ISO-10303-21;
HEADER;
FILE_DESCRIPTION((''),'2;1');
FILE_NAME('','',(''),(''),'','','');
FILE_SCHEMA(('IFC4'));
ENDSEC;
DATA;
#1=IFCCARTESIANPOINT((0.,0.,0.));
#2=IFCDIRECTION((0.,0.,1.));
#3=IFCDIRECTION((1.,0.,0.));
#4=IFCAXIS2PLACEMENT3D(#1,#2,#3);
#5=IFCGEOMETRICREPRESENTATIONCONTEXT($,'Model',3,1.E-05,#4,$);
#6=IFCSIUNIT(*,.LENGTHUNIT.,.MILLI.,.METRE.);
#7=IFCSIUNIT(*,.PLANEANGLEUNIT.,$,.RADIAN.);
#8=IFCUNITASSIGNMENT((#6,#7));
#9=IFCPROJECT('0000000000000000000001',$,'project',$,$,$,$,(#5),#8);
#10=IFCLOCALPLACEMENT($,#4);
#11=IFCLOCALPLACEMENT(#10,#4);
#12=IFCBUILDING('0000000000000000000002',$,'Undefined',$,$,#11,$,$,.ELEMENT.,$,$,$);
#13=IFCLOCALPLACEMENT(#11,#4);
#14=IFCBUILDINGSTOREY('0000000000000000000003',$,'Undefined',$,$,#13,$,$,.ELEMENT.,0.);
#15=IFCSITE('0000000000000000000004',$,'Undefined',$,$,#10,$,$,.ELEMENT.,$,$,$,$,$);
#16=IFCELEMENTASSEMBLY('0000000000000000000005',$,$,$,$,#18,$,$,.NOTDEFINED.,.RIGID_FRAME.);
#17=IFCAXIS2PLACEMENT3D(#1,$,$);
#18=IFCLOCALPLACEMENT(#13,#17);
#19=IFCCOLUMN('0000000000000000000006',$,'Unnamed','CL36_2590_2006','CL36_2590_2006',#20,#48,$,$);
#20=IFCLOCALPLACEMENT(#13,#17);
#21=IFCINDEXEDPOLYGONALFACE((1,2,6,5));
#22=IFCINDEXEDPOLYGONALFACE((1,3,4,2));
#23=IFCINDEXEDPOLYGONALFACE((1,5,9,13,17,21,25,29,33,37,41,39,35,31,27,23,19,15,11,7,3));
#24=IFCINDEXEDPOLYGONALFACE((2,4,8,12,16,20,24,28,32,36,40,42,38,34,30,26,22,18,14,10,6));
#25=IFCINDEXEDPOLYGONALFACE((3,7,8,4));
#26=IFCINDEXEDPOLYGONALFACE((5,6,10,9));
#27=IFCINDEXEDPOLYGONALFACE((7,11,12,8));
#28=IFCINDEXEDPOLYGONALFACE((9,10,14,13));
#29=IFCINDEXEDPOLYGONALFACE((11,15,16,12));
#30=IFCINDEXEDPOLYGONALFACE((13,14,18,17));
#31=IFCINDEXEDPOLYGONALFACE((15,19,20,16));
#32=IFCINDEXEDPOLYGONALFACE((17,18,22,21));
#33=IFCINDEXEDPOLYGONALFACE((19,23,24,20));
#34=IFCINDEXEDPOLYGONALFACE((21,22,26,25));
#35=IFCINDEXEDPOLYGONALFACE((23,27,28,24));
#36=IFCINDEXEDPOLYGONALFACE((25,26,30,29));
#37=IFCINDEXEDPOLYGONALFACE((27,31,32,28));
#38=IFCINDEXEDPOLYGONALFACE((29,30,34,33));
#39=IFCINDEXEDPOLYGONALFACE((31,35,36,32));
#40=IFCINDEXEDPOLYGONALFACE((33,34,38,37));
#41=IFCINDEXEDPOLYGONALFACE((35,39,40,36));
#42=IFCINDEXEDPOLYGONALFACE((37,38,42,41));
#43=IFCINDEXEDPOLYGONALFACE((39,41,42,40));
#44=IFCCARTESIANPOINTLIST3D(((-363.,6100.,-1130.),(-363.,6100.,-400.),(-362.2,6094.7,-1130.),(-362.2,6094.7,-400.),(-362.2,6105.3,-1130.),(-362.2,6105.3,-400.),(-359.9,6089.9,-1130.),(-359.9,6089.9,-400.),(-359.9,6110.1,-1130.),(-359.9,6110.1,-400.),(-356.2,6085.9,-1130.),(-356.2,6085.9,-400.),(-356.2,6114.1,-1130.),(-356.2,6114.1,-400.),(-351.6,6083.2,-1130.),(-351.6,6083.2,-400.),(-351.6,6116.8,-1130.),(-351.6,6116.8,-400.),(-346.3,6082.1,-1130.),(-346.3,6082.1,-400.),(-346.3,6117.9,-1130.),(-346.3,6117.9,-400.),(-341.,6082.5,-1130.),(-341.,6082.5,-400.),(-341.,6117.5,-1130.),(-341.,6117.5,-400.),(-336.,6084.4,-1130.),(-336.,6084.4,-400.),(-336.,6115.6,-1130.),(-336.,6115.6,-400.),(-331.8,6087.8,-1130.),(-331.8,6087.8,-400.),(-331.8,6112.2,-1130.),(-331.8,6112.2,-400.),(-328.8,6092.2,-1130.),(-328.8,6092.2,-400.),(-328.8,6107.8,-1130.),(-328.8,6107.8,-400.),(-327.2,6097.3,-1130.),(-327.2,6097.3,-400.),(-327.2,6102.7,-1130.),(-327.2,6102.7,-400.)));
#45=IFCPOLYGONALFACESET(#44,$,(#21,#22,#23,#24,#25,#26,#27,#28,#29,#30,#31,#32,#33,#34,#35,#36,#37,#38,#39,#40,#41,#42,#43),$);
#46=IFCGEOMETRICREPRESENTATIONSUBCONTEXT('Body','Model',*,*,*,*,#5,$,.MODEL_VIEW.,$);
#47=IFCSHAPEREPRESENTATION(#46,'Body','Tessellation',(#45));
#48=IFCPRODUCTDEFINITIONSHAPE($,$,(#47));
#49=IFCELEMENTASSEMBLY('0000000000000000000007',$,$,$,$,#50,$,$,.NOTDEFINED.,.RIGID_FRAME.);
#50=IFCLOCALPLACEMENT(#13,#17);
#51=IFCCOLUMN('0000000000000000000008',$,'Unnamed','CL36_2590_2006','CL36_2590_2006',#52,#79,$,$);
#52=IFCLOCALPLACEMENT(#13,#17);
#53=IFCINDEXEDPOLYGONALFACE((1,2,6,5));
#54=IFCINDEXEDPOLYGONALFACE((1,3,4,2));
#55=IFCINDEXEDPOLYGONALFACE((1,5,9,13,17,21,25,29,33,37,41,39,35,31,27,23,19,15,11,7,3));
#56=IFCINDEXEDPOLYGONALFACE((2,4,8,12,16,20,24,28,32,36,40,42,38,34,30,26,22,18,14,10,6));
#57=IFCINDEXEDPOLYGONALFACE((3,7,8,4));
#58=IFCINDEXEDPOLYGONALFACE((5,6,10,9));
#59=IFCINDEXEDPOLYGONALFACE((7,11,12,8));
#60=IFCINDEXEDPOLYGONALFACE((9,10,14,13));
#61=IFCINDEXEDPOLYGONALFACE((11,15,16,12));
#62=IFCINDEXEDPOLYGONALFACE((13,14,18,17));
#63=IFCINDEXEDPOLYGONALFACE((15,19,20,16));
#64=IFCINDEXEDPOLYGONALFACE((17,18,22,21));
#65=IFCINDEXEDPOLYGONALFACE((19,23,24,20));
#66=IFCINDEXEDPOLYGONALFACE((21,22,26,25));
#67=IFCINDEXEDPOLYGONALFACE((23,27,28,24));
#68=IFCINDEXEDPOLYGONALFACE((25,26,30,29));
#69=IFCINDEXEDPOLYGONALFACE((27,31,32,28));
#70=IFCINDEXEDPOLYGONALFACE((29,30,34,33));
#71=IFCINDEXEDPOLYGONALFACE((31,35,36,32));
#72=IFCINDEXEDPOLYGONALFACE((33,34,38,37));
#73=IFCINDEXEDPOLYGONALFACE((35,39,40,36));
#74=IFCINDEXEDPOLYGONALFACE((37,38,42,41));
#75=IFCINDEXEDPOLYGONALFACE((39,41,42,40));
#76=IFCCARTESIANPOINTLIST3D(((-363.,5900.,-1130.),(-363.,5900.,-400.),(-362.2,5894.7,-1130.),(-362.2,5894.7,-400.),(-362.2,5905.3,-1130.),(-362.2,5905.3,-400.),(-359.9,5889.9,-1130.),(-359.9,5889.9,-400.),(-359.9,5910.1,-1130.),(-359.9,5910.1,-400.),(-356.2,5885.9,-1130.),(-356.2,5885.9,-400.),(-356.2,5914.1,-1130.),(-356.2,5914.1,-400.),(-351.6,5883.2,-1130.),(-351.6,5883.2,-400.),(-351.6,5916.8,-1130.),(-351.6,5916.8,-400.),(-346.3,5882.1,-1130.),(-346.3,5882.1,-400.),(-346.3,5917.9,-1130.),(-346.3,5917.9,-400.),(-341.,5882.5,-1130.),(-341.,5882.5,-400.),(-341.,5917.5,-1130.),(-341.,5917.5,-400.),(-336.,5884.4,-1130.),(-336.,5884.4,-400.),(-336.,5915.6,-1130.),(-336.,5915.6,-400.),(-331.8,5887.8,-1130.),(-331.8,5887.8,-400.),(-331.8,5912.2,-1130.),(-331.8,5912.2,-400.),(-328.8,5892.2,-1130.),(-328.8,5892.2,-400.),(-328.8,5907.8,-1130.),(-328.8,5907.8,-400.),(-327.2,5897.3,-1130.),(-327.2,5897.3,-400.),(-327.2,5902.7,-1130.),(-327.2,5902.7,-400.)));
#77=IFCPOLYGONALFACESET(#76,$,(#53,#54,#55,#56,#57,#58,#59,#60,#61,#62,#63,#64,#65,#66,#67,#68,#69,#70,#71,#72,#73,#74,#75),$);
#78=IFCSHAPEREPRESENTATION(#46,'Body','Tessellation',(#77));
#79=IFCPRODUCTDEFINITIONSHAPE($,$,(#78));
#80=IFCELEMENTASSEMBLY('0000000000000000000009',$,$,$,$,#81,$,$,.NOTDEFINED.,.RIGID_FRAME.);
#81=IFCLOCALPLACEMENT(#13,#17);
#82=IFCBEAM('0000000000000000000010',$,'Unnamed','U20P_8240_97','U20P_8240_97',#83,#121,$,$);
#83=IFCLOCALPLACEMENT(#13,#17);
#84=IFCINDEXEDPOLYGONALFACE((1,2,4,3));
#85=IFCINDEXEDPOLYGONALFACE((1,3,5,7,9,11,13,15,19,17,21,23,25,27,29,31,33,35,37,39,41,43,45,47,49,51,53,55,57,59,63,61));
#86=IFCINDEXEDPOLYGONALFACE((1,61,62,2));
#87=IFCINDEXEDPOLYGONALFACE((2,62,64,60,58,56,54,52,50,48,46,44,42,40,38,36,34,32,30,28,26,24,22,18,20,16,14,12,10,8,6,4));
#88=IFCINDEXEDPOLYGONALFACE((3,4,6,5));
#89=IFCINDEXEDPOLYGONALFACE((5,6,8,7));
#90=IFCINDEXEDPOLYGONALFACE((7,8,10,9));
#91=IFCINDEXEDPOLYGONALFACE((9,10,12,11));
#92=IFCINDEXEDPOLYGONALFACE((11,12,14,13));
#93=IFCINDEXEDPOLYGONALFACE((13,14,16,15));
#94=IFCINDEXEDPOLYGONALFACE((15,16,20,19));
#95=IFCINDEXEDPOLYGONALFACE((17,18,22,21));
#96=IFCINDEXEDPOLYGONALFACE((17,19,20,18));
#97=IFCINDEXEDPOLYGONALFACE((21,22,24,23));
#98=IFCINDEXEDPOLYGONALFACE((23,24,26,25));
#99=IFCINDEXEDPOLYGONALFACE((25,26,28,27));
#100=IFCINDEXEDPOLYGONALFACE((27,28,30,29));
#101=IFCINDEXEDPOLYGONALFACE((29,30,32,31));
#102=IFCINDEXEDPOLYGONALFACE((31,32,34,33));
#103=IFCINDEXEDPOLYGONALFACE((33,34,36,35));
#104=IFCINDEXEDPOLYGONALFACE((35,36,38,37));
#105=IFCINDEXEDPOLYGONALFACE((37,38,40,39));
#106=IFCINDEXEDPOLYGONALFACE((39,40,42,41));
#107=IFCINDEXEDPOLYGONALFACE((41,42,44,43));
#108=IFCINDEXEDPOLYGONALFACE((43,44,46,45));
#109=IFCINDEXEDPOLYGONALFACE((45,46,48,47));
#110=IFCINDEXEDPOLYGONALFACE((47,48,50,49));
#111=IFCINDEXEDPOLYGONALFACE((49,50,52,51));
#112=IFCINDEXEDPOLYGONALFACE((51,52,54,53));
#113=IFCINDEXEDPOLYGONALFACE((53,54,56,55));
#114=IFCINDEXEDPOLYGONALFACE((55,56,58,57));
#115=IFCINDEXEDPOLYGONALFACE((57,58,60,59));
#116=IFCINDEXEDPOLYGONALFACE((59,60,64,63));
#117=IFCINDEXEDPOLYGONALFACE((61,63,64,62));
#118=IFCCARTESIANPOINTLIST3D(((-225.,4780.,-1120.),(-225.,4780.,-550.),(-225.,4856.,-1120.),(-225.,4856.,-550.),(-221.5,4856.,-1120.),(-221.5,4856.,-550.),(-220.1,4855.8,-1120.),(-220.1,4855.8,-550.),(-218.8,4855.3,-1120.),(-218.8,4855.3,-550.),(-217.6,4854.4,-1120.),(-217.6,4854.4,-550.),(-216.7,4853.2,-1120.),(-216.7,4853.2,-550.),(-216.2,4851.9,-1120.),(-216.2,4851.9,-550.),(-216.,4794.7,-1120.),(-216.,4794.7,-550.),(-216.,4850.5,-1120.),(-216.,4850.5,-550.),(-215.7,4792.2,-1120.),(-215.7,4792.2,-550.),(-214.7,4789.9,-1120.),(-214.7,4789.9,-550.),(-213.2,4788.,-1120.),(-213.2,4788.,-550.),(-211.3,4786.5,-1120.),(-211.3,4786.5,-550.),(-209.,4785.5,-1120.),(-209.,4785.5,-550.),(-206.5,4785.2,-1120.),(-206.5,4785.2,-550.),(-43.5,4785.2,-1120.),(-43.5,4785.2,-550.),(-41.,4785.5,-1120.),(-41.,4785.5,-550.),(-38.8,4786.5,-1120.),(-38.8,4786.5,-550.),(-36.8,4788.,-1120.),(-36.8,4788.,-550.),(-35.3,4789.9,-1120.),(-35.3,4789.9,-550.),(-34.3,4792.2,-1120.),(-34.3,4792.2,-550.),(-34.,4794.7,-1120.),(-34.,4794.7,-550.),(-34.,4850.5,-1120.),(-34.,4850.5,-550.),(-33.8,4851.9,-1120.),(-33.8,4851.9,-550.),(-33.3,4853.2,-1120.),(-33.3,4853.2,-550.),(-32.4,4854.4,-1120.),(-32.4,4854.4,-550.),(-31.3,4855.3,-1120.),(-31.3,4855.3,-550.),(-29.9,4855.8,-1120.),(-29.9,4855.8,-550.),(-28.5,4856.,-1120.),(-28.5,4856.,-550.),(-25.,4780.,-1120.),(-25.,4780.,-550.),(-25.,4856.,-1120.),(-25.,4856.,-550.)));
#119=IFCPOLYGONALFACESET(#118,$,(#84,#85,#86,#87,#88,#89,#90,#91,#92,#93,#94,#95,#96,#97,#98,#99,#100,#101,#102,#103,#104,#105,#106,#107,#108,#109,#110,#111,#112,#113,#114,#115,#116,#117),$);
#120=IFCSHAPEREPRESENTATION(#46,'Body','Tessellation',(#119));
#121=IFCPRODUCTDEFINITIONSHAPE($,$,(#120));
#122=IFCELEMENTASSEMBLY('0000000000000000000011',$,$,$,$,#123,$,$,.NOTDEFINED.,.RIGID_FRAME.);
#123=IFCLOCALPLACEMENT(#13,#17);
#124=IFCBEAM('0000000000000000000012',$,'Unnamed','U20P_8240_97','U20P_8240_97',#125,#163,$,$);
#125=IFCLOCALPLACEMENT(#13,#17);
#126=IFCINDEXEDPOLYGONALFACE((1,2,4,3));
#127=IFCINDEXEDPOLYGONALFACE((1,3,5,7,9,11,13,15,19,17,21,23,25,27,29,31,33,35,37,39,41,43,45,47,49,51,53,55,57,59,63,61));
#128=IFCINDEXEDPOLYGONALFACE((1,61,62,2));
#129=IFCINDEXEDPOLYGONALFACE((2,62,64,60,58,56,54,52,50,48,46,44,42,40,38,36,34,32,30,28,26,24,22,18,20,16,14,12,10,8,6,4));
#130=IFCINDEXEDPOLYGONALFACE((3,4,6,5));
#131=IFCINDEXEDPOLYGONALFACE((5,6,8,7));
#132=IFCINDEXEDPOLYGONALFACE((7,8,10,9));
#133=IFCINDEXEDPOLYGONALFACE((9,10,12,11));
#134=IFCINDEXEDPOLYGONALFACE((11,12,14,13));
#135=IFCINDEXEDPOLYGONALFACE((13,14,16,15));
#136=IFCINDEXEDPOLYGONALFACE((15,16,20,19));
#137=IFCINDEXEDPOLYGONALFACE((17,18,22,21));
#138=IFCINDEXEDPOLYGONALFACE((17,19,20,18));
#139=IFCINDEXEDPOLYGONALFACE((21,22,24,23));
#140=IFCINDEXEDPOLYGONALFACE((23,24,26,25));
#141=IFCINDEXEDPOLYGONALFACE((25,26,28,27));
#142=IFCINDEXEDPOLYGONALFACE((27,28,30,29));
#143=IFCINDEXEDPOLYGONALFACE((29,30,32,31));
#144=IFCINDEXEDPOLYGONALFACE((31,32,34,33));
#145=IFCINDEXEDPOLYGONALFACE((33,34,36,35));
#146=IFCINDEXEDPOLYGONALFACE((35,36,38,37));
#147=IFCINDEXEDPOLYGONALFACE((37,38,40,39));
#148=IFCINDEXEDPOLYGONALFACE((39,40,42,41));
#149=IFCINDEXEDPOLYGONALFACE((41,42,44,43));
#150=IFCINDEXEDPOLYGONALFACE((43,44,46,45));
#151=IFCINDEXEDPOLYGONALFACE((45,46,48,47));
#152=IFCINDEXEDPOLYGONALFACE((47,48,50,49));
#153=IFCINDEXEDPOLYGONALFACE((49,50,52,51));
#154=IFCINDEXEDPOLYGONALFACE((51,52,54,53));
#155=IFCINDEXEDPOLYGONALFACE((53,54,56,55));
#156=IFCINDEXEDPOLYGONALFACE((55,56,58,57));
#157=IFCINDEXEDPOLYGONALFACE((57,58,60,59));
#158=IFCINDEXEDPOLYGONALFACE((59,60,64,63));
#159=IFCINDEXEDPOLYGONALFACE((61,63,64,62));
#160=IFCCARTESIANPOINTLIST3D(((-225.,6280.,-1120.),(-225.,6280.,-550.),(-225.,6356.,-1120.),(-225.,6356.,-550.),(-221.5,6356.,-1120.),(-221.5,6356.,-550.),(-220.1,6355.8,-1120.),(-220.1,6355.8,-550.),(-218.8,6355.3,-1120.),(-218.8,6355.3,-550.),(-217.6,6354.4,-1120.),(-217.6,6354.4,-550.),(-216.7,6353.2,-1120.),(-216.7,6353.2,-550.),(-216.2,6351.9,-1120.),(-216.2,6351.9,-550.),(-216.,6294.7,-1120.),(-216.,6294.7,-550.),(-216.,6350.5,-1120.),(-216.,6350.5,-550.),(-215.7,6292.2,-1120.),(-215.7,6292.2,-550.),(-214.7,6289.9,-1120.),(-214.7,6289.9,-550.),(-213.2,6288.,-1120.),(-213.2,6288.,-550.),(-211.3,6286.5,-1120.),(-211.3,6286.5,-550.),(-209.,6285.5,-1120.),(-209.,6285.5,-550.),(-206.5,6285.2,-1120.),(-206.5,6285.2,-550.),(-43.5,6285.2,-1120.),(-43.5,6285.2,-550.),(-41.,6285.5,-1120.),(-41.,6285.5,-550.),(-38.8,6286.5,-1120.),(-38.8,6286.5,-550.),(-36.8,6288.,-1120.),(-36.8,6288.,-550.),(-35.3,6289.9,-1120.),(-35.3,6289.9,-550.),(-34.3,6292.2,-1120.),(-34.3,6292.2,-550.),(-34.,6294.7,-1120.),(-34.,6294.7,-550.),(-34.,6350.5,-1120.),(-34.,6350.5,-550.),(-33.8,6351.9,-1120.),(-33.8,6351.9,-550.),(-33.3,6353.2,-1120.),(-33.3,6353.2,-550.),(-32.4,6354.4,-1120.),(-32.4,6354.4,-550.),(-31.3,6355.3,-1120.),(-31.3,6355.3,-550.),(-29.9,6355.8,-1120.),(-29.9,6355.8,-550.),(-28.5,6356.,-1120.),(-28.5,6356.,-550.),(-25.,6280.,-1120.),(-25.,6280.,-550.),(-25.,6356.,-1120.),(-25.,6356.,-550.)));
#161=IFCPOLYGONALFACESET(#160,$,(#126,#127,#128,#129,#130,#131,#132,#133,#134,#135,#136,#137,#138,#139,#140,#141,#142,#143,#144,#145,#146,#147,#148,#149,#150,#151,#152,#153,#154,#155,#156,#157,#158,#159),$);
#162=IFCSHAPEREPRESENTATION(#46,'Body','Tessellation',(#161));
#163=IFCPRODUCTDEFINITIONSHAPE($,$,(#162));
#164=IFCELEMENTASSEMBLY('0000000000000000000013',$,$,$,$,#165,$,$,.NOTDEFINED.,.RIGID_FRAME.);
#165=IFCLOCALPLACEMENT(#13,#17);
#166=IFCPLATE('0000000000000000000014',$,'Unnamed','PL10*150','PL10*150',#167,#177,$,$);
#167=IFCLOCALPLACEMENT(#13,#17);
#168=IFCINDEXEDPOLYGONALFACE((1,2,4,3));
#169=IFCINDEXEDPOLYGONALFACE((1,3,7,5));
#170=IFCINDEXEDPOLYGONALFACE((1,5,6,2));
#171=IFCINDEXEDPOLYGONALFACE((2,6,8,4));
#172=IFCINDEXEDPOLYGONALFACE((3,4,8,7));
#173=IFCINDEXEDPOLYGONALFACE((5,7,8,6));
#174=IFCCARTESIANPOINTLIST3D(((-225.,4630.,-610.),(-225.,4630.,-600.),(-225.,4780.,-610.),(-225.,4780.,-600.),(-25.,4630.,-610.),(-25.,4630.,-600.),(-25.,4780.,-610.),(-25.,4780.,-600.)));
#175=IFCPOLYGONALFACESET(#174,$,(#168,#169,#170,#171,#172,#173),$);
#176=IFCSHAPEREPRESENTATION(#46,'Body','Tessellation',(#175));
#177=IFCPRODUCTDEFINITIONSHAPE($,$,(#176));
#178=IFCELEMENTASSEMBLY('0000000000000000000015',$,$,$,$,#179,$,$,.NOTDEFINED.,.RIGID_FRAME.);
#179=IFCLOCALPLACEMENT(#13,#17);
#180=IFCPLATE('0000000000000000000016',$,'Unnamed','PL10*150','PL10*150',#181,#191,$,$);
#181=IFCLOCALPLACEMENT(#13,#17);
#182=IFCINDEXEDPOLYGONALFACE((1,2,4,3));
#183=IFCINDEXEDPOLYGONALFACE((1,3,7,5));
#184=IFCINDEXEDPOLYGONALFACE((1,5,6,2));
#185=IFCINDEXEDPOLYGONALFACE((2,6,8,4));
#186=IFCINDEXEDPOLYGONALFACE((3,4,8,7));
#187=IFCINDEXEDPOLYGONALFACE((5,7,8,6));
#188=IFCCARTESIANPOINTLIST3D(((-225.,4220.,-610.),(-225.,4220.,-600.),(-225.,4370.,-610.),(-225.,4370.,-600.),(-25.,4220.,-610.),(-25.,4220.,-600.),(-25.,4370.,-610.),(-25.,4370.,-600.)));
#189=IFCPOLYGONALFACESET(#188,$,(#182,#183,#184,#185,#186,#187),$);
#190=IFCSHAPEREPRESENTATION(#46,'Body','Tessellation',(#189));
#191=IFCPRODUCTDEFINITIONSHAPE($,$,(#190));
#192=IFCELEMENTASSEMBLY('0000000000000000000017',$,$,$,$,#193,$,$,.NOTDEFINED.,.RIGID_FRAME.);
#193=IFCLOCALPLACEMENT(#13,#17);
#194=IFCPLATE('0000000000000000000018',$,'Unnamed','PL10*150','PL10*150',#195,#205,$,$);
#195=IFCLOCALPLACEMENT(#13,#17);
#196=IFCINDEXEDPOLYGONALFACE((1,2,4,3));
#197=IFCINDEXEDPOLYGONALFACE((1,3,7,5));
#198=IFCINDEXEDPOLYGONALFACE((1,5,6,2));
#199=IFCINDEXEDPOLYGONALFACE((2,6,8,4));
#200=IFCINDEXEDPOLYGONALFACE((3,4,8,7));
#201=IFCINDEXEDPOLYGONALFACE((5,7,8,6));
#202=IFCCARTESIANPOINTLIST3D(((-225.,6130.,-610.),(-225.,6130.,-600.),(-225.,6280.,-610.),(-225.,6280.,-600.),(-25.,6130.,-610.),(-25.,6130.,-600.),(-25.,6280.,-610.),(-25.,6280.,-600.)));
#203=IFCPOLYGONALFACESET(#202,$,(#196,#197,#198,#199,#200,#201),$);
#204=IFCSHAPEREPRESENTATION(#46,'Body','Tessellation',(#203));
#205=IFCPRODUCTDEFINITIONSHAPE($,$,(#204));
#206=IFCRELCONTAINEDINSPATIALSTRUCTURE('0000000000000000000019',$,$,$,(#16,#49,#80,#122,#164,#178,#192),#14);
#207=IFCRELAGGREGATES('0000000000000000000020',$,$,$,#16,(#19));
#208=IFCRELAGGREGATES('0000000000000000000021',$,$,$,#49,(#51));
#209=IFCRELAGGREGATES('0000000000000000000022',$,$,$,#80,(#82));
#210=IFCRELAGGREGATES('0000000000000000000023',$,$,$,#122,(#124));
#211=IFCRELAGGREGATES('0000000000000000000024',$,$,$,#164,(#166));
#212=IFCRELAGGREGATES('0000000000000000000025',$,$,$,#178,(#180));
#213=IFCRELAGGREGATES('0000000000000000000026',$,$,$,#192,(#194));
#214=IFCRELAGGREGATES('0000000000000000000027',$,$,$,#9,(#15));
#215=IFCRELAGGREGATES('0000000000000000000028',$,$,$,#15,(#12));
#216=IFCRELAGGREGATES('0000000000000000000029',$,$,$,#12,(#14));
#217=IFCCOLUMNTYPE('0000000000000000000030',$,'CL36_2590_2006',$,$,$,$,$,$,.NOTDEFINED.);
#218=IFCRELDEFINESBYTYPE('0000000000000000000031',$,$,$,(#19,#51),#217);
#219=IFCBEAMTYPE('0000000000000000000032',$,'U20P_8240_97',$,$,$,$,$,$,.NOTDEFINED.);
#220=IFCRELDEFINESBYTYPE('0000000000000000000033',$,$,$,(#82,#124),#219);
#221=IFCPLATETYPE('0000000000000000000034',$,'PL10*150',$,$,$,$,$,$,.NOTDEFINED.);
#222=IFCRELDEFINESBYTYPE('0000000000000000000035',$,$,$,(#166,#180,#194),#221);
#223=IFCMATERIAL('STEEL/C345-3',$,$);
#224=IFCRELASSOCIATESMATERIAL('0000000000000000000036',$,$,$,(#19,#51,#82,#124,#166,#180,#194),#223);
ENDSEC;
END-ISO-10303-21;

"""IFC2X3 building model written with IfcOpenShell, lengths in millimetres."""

from ifc_helpers import new_model, si_unit, frame, origin_with_axes, origin_2d_with_axis, place, context, subcontext, project, spatial, polyline, circle, u_section, outline, extrude, material, type_object, element, aggregate, save


model = new_model("IFC2X3")

# Units and contexts
model_context = context("Model", 3, precision=1e-05, world=origin_with_axes())
body_context = subcontext(model_context, "Body", "Model", "MODEL_VIEW")
ifc_project = project(units=[si_unit("LENGTHUNIT", "METRE", prefix="MILLI"), si_unit("PLANEANGLEUNIT", "RADIAN")], contexts=[model_context])

# Site, building, storey
site_placement = place(None, origin_with_axes())
site = spatial("IfcSite", under=ifc_project, at=site_placement, Name="Undefined", CompositionType="ELEMENT")
building_placement = place(site_placement, origin_with_axes())
building = spatial("IfcBuilding", under=site, at=building_placement, Name="Undefined", CompositionType="ELEMENT")
storey_placement = place(building_placement, origin_with_axes())
storey = spatial("IfcBuildingStorey", under=building, at=storey_placement, Name="Undefined", CompositionType="ELEMENT", Elevation=0.0)

# Element assemblies, columns
ifc_material_1 = material(Name="STEEL/C345-3")
column_type_1 = type_object("IfcColumnType", Name="CL36_2590_2006", PredefinedType="NOTDEFINED")
assembly_1_placement = place(storey_placement, origin_with_axes())
assembly_1 = element("IfcElementAssembly", 1, at=assembly_1_placement, inside=storey, AssemblyPlace="NOTDEFINED", PredefinedType="RIGID_FRAME")
column_1_placement = place(assembly_1_placement, frame((-345.0, 6100.0, -1130.0), z_axis=(0.0, 0.0, 1.0), x_axis=(0.0, 1.0, 0.0)))
column_1 = element("IfcColumn", 2, at=column_1_placement, type_object=column_type_1, material=ifc_material_1, Name="Unnamed", Description="CL36_2590_2006", ObjectType="CL36_2590_2006", context=body_context, shape_type="SweptSolid", body=[
    extrude(circle(Radius=18.0, at=origin_2d_with_axis()), frame((0.0, 0.0, 730.0), z_axis=(0.0, 0.0, -1.0), x_axis=(0.0, 1.0, 0.0)), (0.0, 0.0, 1.0), 730.0),
])
aggregate(assembly_1, [column_1])
assembly_2_placement = place(storey_placement, origin_with_axes())
assembly_2 = element("IfcElementAssembly", 3, at=assembly_2_placement, inside=storey, AssemblyPlace="NOTDEFINED", PredefinedType="RIGID_FRAME")
column_2_placement = place(assembly_2_placement, frame((-345.0, 5900.0, -1130.0), z_axis=(0.0, 0.0, 1.0), x_axis=(0.0, 1.0, 0.0)))
column_2 = element("IfcColumn", 4, at=column_2_placement, type_object=column_type_1, material=ifc_material_1, Name="Unnamed", Description="CL36_2590_2006", ObjectType="CL36_2590_2006", context=body_context, shape_type="SweptSolid", body=[
    extrude(circle(Radius=18.0, at=origin_2d_with_axis()), frame((0.0, 0.0, 730.0), z_axis=(0.0, 0.0, -1.0), x_axis=(0.0, 1.0, 0.0)), (0.0, 0.0, 1.0), 730.0),
])
aggregate(assembly_2, [column_2])

# Element assemblies, beams
assembly_3_placement = place(storey_placement, origin_with_axes())
assembly_3 = element("IfcElementAssembly", 5, at=assembly_3_placement, inside=storey, AssemblyPlace="NOTDEFINED", PredefinedType="RIGID_FRAME")
beam_type = type_object("IfcBeamType", Name="U20P_8240_97", PredefinedType="NOTDEFINED")
beam_1_placement = place(assembly_3_placement, frame((-125.0, 4818.0, -550.0), z_axis=(-1.0, 0.0, 0.0), x_axis=(0.0, 0.0, -1.0)))
beam_1 = element("IfcBeam", 6, at=beam_1_placement, type_object=beam_type, material=ifc_material_1, Name="Unnamed", Description="U20P_8240_97", ObjectType="U20P_8240_97", context=body_context, shape_type="SweptSolid", body=[
    extrude(u_section(Depth=200.0, FlangeWidth=76.0, WebThickness=5.2, FlangeThickness=9.0, FilletRadius=9.5, EdgeRadius=5.5, at=origin_2d_with_axis()), frame((570.0, 0.0, 0.0), z_axis=(-1.0, 0.0, 0.0), x_axis=(0.0, -1.0, 0.0)), (0.0, 0.0, 1.0), 570.0),
])
aggregate(assembly_3, [beam_1])
assembly_4_placement = place(storey_placement, origin_with_axes())
assembly_4 = element("IfcElementAssembly", 7, at=assembly_4_placement, inside=storey, AssemblyPlace="NOTDEFINED", PredefinedType="RIGID_FRAME")
beam_2_placement = place(assembly_4_placement, frame((-125.0, 6318.0, -550.0), z_axis=(-1.0, 0.0, 0.0), x_axis=(0.0, 0.0, -1.0)))
beam_2 = element("IfcBeam", 8, at=beam_2_placement, type_object=beam_type, material=ifc_material_1, Name="Unnamed", Description="U20P_8240_97", ObjectType="U20P_8240_97", context=body_context, shape_type="SweptSolid", body=[
    extrude(u_section(Depth=200.0, FlangeWidth=76.0, WebThickness=5.2, FlangeThickness=9.0, FilletRadius=9.5, EdgeRadius=5.5, at=origin_2d_with_axis()), frame((570.0, 0.0, 0.0), z_axis=(-1.0, 0.0, 0.0), x_axis=(0.0, -1.0, 0.0)), (0.0, 0.0, 1.0), 570.0),
])
aggregate(assembly_4, [beam_2])

# Element assemblies, plates
assembly_5_placement = place(storey_placement, origin_with_axes())
assembly_5 = element("IfcElementAssembly", 9, at=assembly_5_placement, inside=storey, AssemblyPlace="NOTDEFINED", PredefinedType="RIGID_FRAME")
plate_type_1 = type_object("IfcPlateType", Name="PL10*150", PredefinedType="NOTDEFINED")
plate_1_placement = place(assembly_5_placement, frame((-25.0, 4630.0, -605.0), z_axis=(0.0, 0.0, 1.0), x_axis=(0.0, 1.0, 0.0)))
plate_1 = element("IfcPlate", 10, at=plate_1_placement, type_object=plate_type_1, material=ifc_material_1, Name="Unnamed", Description="PL10*150", ObjectType="PL10*150", context=body_context, shape_type="SweptSolid", body=[
    extrude(outline(polyline([(0.0, 0.0), (150.0, 0.0), (150.0, 200.0), (0.0, 200.0), (0.0, 0.0)])), frame((0.0, 0.0, -5.0), z_axis=(0.0, 0.0, 1.0), x_axis=(1.0, 0.0, 0.0)), (0.0, 0.0, 1.0), 10.0),
])
aggregate(assembly_5, [plate_1])
assembly_6_placement = place(storey_placement, origin_with_axes())
assembly_6 = element("IfcElementAssembly", 11, at=assembly_6_placement, inside=storey, AssemblyPlace="NOTDEFINED", PredefinedType="RIGID_FRAME")
plate_2_placement = place(assembly_6_placement, frame((-25.0, 4370.0, -605.0), z_axis=(0.0, 0.0, -1.0), x_axis=(0.0, -1.0, 0.0)))
plate_2 = element("IfcPlate", 12, at=plate_2_placement, type_object=plate_type_1, material=ifc_material_1, Name="Unnamed", Description="PL10*150", ObjectType="PL10*150", context=body_context, shape_type="SweptSolid", body=[
    extrude(outline(polyline([(0.0, 0.0), (150.0, 0.0), (150.0, 200.0), (0.0, 200.0), (0.0, 0.0)])), frame((0.0, 0.0, -5.0), z_axis=(0.0, 0.0, 1.0), x_axis=(1.0, 0.0, 0.0)), (0.0, 0.0, 1.0), 10.0),
])
aggregate(assembly_6, [plate_2])
assembly_7_placement = place(storey_placement, origin_with_axes())
assembly_7 = element("IfcElementAssembly", 13, at=assembly_7_placement, inside=storey, AssemblyPlace="NOTDEFINED", PredefinedType="RIGID_FRAME")
plate_3_placement = place(assembly_7_placement, frame((-25.0, 6130.0, -605.0), z_axis=(0.0, 0.0, 1.0), x_axis=(0.0, 1.0, 0.0)))
plate_3 = element("IfcPlate", 14, at=plate_3_placement, type_object=plate_type_1, material=ifc_material_1, Name="Unnamed", Description="PL10*150", ObjectType="PL10*150", context=body_context, shape_type="SweptSolid", body=[
    extrude(outline(polyline([(0.0, 0.0), (150.0, 0.0), (150.0, 200.0), (0.0, 200.0), (0.0, 0.0)])), frame((0.0, 0.0, -5.0), z_axis=(0.0, 0.0, 1.0), x_axis=(1.0, 0.0, 0.0)), (0.0, 0.0, 1.0), 10.0),
])
aggregate(assembly_7, [plate_3])

save(model, "model.ifc")
